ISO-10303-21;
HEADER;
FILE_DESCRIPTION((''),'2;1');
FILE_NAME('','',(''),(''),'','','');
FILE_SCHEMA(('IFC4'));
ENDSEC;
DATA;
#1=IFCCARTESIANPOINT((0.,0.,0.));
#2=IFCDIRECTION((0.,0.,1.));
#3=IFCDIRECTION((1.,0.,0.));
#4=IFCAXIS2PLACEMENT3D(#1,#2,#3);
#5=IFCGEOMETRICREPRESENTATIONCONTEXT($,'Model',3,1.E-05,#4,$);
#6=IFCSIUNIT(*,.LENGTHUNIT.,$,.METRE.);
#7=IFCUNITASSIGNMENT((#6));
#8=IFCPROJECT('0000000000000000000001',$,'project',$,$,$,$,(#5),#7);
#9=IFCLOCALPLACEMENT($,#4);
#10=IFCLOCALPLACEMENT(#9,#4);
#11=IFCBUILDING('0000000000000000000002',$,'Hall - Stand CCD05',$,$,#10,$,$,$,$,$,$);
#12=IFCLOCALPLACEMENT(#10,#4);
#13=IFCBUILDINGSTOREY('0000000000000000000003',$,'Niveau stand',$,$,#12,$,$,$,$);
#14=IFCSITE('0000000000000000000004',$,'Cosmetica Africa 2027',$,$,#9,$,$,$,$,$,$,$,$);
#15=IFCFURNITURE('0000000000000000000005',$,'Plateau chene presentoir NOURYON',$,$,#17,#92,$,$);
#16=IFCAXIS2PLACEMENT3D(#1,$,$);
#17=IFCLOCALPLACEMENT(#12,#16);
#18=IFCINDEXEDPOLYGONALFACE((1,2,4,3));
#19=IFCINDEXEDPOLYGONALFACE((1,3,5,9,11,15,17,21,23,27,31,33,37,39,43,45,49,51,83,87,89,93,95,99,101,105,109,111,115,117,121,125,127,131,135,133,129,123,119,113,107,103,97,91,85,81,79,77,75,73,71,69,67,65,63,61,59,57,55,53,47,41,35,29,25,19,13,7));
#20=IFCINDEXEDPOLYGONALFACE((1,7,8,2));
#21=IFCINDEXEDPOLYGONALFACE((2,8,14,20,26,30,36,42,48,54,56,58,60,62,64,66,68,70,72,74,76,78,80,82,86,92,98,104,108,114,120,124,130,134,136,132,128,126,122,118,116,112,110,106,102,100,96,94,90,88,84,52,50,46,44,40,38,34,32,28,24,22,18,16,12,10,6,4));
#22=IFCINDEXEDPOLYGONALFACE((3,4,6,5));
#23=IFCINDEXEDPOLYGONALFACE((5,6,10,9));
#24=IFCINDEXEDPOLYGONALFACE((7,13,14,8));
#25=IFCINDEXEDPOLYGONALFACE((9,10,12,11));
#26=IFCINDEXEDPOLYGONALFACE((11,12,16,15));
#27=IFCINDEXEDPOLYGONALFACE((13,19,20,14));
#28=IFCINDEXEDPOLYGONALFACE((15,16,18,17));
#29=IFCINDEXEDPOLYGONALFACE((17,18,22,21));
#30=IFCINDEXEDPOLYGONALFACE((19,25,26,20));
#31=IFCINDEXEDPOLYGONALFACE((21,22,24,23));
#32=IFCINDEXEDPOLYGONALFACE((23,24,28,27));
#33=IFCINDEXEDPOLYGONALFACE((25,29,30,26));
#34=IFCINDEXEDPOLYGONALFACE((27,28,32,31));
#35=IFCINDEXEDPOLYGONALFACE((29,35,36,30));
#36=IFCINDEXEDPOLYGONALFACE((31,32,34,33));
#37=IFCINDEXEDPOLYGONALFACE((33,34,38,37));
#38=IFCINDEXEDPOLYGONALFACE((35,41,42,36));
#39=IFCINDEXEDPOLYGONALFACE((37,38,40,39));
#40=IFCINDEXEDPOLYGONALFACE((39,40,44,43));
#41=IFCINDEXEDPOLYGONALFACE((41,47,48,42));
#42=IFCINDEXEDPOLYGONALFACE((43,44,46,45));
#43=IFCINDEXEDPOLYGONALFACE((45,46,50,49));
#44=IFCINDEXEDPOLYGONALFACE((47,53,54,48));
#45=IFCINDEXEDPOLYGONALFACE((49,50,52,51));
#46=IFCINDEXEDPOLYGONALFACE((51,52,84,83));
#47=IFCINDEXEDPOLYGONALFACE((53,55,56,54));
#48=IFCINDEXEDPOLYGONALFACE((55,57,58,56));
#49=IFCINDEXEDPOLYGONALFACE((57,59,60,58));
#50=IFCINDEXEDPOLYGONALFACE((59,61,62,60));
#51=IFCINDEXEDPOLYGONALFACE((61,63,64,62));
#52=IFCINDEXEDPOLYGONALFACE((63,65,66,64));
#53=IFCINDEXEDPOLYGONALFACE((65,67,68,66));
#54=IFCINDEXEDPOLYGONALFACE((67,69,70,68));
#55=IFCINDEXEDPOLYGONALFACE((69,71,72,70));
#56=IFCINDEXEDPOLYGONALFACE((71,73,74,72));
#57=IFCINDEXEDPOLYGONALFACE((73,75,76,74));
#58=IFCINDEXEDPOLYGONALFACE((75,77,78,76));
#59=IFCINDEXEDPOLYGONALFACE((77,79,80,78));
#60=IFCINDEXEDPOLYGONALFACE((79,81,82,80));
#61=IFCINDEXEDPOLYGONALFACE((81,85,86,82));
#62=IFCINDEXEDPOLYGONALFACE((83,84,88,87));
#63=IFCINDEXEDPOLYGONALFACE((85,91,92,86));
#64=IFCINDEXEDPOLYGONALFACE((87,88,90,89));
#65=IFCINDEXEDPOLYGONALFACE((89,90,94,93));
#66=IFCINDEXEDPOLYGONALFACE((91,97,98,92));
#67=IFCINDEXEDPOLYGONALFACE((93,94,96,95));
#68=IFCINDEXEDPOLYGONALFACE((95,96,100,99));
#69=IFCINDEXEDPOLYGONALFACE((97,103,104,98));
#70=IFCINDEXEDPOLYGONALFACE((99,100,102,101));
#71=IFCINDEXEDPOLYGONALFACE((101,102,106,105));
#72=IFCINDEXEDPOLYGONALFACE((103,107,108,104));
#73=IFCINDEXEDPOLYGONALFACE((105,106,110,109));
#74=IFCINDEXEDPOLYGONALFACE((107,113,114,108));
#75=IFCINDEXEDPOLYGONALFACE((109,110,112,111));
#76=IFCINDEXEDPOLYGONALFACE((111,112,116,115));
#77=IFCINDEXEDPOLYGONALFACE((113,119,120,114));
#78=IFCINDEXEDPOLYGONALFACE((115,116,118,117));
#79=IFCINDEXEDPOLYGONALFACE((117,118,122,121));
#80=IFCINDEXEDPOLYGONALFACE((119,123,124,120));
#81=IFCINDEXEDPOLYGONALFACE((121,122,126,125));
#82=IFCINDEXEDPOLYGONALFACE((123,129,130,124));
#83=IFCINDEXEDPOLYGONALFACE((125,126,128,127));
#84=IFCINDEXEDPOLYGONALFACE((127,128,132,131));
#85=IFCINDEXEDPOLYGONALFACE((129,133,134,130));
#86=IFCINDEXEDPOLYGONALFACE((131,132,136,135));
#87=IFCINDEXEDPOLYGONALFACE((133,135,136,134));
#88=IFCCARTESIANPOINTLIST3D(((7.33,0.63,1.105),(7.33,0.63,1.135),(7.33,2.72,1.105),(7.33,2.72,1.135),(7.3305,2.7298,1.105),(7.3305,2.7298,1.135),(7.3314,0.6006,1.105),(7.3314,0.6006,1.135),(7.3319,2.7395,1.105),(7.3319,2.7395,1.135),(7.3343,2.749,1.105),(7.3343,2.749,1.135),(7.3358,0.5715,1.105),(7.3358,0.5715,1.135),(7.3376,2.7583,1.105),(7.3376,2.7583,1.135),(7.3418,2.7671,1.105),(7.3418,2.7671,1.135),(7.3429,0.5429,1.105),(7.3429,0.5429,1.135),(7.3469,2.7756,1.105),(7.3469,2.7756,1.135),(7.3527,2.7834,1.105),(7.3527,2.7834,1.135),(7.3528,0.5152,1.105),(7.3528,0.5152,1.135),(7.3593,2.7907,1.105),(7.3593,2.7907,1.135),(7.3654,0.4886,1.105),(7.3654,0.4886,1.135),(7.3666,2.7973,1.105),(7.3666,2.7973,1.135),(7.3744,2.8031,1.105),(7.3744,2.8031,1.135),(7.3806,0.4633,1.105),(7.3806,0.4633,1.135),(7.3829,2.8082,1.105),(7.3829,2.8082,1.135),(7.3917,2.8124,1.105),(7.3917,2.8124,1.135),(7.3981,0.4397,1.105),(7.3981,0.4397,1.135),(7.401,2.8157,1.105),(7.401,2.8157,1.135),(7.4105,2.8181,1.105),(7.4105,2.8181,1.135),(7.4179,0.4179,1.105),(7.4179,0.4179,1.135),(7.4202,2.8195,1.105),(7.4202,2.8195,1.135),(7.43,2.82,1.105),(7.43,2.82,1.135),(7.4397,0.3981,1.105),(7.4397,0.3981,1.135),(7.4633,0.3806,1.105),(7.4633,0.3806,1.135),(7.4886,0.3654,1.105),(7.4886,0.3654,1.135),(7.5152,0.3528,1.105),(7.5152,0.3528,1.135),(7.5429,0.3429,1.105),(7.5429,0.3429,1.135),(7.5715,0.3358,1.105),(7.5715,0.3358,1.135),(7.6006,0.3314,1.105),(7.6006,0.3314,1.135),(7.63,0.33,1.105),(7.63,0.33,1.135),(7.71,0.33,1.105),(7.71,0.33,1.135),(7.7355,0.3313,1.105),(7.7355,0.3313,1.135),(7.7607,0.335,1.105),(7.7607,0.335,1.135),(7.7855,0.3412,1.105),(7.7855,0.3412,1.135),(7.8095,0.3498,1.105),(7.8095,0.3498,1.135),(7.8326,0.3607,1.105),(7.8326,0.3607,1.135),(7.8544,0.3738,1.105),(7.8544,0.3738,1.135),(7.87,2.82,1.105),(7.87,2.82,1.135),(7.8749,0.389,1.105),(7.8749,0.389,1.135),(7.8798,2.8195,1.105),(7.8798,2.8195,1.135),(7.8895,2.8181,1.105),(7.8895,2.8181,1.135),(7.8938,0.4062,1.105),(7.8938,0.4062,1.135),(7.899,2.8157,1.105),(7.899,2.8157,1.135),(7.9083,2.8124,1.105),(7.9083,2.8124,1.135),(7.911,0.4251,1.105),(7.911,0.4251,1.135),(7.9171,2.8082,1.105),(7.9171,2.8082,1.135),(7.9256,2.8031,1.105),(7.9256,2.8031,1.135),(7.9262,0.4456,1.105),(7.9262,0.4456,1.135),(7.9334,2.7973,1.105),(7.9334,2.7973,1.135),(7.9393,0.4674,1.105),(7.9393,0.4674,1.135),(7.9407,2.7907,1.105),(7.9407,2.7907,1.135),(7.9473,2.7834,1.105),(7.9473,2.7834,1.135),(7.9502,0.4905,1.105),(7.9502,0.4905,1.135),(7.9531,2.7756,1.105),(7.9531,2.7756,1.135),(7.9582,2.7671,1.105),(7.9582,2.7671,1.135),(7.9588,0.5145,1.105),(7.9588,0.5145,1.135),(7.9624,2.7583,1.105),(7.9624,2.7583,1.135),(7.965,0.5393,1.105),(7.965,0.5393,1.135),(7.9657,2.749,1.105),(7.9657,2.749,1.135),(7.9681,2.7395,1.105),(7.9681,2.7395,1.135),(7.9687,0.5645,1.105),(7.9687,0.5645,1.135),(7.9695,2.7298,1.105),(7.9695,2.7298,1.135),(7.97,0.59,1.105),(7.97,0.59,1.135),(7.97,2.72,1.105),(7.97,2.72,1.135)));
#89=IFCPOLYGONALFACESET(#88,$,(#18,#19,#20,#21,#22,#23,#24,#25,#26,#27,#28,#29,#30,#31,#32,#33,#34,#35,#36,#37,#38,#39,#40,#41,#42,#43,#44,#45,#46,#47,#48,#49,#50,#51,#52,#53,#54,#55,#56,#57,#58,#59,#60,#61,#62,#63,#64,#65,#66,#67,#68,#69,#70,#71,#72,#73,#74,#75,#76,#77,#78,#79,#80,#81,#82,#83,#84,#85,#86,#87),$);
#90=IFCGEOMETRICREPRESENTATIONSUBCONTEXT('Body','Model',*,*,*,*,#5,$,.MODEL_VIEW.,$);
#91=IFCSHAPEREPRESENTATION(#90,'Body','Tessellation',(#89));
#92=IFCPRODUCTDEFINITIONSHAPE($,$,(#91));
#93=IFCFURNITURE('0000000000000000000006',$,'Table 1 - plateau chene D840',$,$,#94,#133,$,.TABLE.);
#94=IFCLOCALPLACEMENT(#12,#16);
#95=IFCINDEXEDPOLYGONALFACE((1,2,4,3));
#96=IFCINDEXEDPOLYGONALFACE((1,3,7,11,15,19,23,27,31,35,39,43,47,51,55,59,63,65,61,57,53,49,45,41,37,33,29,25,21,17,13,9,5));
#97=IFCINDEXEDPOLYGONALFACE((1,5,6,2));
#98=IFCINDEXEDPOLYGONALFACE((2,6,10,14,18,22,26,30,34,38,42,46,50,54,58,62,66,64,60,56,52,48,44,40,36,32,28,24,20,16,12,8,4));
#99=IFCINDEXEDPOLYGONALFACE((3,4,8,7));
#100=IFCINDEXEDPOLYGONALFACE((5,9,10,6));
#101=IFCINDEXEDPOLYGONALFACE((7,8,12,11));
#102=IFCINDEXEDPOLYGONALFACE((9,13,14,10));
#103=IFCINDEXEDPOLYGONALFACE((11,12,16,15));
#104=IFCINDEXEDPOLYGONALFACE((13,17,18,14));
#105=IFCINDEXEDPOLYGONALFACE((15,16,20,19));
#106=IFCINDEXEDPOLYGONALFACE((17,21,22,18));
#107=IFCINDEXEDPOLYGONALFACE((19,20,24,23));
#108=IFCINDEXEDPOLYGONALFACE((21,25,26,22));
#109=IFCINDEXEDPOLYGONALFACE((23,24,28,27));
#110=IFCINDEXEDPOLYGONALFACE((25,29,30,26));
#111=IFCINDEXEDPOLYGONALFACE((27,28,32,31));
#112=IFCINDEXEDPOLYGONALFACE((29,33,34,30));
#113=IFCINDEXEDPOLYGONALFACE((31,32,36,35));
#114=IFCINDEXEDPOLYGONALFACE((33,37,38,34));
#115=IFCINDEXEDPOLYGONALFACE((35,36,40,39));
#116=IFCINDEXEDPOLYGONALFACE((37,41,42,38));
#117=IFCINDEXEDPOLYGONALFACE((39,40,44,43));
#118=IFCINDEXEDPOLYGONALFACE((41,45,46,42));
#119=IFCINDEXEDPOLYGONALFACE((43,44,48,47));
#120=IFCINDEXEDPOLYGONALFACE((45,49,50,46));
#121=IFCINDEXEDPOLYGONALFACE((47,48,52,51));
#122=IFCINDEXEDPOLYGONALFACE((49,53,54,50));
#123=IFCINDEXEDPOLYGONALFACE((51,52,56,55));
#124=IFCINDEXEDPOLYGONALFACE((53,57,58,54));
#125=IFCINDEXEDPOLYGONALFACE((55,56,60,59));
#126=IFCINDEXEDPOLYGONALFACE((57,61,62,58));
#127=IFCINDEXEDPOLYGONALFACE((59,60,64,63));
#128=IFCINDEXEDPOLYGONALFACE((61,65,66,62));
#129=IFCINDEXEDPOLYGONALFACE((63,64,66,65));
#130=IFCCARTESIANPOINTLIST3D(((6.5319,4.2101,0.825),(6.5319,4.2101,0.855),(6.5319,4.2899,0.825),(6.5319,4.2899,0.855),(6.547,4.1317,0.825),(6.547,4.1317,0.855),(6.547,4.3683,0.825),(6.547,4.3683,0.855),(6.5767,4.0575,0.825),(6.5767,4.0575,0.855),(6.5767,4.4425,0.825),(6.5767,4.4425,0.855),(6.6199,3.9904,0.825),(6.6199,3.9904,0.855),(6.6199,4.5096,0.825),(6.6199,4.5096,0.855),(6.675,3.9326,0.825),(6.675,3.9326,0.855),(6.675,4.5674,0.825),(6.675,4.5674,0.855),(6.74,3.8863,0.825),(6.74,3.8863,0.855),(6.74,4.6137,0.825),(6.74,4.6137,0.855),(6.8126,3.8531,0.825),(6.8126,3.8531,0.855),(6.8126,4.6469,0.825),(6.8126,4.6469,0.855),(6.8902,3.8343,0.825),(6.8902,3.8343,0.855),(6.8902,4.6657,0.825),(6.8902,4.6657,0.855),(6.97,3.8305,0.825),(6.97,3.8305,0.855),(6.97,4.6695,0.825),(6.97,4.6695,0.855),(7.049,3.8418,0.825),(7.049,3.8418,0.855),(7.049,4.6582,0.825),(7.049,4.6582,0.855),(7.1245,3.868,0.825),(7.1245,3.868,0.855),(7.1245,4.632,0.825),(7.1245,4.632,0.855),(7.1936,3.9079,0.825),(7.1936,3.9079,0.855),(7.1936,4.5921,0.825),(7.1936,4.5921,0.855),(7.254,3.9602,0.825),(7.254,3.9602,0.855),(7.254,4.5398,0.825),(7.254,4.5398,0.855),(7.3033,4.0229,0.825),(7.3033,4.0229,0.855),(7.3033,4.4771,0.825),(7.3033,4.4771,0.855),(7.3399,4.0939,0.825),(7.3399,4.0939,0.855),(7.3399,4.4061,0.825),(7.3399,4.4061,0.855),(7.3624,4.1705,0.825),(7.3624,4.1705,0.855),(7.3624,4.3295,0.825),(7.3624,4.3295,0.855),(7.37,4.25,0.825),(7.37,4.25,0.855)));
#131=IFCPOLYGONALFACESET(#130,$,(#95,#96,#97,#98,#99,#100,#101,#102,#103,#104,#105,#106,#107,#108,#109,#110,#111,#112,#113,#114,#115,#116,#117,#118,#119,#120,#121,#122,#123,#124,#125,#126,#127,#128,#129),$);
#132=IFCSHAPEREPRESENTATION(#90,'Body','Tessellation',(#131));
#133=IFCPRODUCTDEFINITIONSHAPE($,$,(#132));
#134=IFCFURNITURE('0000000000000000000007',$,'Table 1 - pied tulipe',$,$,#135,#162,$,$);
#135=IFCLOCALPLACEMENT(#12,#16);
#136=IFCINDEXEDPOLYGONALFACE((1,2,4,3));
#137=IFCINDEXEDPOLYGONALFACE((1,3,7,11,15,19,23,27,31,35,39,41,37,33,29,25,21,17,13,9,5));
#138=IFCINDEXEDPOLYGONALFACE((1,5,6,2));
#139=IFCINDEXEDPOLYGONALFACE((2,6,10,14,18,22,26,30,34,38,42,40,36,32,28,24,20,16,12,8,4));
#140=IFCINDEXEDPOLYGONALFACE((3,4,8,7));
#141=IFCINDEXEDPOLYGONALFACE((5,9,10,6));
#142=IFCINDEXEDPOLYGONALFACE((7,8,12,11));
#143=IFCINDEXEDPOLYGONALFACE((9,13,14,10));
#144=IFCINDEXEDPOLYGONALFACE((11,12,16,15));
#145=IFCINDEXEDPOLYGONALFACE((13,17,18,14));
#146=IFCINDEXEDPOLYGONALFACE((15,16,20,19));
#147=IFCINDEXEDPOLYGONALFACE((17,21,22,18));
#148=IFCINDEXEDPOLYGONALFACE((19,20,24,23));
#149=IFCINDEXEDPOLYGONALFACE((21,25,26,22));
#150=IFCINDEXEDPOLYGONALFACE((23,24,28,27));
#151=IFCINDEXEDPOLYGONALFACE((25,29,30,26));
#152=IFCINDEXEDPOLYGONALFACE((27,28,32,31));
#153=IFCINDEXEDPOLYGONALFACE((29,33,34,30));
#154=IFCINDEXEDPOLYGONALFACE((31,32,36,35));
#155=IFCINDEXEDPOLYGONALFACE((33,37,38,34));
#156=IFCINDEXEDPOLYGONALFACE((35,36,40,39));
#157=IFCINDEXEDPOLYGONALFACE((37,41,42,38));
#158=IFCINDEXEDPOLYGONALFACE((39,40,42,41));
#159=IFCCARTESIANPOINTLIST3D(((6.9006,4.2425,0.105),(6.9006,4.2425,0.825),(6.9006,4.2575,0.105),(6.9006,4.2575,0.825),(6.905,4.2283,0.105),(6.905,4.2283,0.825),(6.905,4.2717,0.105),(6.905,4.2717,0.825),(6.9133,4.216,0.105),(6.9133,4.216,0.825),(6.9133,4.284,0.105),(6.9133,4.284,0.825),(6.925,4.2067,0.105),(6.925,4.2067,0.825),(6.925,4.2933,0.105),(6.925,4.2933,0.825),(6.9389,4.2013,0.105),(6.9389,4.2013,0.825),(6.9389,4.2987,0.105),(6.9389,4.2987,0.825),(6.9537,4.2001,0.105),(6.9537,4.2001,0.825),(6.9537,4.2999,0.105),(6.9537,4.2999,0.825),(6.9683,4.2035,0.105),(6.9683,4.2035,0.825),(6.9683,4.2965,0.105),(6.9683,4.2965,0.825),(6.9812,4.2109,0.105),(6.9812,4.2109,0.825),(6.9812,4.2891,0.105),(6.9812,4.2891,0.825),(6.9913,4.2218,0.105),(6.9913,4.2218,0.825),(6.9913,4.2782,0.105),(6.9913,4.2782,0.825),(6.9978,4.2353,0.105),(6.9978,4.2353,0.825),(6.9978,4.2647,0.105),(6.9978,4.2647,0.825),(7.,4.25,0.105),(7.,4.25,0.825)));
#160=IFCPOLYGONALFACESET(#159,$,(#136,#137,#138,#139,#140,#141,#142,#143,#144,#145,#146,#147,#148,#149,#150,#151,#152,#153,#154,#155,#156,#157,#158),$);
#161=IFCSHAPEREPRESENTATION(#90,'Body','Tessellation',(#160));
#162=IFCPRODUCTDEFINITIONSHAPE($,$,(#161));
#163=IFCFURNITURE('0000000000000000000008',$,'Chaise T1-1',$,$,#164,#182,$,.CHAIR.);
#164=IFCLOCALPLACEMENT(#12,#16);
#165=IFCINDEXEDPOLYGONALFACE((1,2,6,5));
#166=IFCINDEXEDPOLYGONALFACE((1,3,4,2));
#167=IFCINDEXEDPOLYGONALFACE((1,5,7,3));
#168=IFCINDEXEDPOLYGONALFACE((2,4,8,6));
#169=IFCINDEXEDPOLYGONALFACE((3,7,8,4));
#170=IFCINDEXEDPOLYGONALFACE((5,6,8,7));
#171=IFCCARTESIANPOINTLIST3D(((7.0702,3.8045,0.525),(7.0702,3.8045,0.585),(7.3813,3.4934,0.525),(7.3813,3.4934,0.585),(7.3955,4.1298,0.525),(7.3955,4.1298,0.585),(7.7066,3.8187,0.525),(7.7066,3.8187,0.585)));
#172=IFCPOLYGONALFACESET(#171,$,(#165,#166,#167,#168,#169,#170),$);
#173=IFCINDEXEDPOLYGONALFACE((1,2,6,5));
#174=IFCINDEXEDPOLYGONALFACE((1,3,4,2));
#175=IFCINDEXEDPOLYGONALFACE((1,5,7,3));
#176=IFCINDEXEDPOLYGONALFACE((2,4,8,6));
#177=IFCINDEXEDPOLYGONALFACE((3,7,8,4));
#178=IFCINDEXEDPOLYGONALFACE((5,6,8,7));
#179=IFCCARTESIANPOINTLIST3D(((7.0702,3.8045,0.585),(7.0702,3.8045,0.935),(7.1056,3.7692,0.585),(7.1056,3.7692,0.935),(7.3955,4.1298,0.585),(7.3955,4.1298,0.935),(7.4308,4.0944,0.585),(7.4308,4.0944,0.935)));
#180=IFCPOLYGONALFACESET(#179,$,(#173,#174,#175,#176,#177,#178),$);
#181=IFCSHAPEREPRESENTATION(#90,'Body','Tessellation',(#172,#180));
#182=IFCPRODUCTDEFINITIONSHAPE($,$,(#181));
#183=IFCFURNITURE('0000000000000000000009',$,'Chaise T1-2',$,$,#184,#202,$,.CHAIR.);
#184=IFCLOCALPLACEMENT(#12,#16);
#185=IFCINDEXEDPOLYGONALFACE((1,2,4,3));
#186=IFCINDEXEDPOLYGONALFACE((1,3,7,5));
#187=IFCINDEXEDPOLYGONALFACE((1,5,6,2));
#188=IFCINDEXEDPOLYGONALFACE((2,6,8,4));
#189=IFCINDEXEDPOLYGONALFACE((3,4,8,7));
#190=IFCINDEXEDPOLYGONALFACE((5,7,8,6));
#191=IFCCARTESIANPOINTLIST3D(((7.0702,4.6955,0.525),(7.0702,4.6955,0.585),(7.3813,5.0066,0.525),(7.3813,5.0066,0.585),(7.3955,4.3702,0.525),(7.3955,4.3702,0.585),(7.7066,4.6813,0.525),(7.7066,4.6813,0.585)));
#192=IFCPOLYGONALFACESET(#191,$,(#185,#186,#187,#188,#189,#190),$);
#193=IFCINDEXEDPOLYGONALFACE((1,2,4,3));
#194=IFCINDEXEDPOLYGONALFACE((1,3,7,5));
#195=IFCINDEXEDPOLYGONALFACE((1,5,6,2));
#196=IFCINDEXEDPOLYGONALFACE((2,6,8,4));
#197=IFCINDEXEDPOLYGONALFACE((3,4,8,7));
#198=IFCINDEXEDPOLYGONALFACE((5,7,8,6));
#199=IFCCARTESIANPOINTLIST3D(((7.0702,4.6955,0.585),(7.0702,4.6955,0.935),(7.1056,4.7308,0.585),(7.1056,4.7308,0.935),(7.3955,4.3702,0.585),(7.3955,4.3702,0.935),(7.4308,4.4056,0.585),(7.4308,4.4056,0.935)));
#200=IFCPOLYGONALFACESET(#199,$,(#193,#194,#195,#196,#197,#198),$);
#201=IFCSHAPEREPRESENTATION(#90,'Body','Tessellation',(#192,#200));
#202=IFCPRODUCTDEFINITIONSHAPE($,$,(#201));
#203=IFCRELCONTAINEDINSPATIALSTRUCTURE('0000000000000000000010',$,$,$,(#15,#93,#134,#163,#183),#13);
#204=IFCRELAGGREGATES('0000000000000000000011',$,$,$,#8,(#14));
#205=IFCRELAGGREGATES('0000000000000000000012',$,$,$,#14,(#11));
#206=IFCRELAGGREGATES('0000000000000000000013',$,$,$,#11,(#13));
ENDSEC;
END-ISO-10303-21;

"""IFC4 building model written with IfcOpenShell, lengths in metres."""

from ifc_helpers import new_model, si_unit, frame, frame_2d, origin_with_axes, place, context, subcontext, project, spatial, polyline, circle, outline, extrude, element, save


model = new_model("IFC4")

# Units and contexts
model_context = context("Model", 3, precision=1e-05, world=origin_with_axes())
body_context = subcontext(model_context, "Body", "Model", "MODEL_VIEW")
ifc_project = project(units=[si_unit("LENGTHUNIT", "METRE")], contexts=[model_context])

# Site, building, storey
site_placement = place(None, origin_with_axes())
site = spatial("IfcSite", under=ifc_project, at=site_placement, Name="Cosmetica Africa 2027")
building_placement = place(site_placement, origin_with_axes())
building = spatial("IfcBuilding", under=site, at=building_placement, Name="Hall - Stand CCD05")
storey_placement = place(building_placement, origin_with_axes())
storey = spatial("IfcBuildingStorey", under=building, at=storey_placement, Name="Niveau stand")

# Furniture
furniture_1_placement = place(storey_placement, origin_with_axes())
element("IfcFurniture", 1, at=furniture_1_placement, inside=storey, Name="Plateau chene presentoir NOURYON", context=body_context, shape_type="SweptSolid", body=[
    extrude(outline(polyline([(7.33, 0.63), (7.3314, 0.6006), (7.3358, 0.5715), (7.3429, 0.5429), (7.3528, 0.5152), (7.3654, 0.4886), (7.3806, 0.4633), (7.3981, 0.4397), (7.4179, 0.4179), (7.4397, 0.3981), (7.4633, 0.3806), (7.4886, 0.3654), (7.5152, 0.3528), (7.5429, 0.3429), (7.5715, 0.3358), (7.6006, 0.3314), (7.63, 0.33), (7.71, 0.33), (7.7355, 0.3313), (7.7607, 0.335), (7.7855, 0.3412), (7.8095, 0.3498), (7.8326, 0.3607), (7.8544, 0.3738), (7.8749, 0.389), (7.8938, 0.4062), (7.911, 0.4251), (7.9262, 0.4456), (7.9393, 0.4674), (7.9502, 0.4905), (7.9588, 0.5145), (7.965, 0.5393), (7.9687, 0.5645), (7.97, 0.59), (7.97, 2.72), (7.9695, 2.7298), (7.9681, 2.7395), (7.9657, 2.749), (7.9624, 2.7583), (7.9582, 2.7671), (7.9531, 2.7756), (7.9473, 2.7834), (7.9407, 2.7907), (7.9334, 2.7973), (7.9256, 2.8031), (7.9171, 2.8082), (7.9083, 2.8124), (7.899, 2.8157), (7.8895, 2.8181), (7.8798, 2.8195), (7.87, 2.82), (7.43, 2.82), (7.4202, 2.8195), (7.4105, 2.8181), (7.401, 2.8157), (7.3917, 2.8124), (7.3829, 2.8082), (7.3744, 2.8031), (7.3666, 2.7973), (7.3593, 2.7907), (7.3527, 2.7834), (7.3469, 2.7756), (7.3418, 2.7671), (7.3376, 2.7583), (7.3343, 2.749), (7.3319, 2.7395), (7.3305, 2.7298), (7.33, 2.72), (7.33, 0.63)])), frame((0.0, 0.0, 1.105)), (0.0, 0.0, 1.0), 0.03),
])
furniture_2_placement = place(storey_placement, origin_with_axes())
element("IfcFurniture", 2, at=furniture_2_placement, inside=storey, Name="Table 1 - plateau chene D840", PredefinedType="TABLE", context=body_context, shape_type="SweptSolid", body=[
    extrude(circle(Radius=0.42, at=frame_2d((6.95, 4.25))), frame((0.0, 0.0, 0.825)), (0.0, 0.0, 1.0), 0.03),
])
furniture_3_placement = place(storey_placement, origin_with_axes())
element("IfcFurniture", 3, at=furniture_3_placement, inside=storey, Name="Table 1 - pied tulipe", context=body_context, shape_type="SweptSolid", body=[
    extrude(circle(Radius=0.05, at=frame_2d((6.95, 4.25))), frame((0.0, 0.0, 0.105)), (0.0, 0.0, 1.0), 0.72),
])
furniture_4_placement = place(storey_placement, origin_with_axes())
element("IfcFurniture", 4, at=furniture_4_placement, inside=storey, Name="Chaise T1-1", PredefinedType="CHAIR", context=body_context, shape_type="SweptSolid", body=[
    extrude(outline(polyline([(7.3813, 3.4934), (7.7066, 3.8187), (7.3955, 4.1298), (7.0702, 3.8045), (7.3813, 3.4934)])), frame((0.0, 0.0, 0.525)), (0.0, 0.0, 1.0), 0.06),
    extrude(outline(polyline([(7.1056, 3.7692), (7.4308, 4.0944), (7.3955, 4.1298), (7.0702, 3.8045), (7.1056, 3.7692)])), frame((0.0, 0.0, 0.585)), (0.0, 0.0, 1.0), 0.35),
])
furniture_5_placement = place(storey_placement, origin_with_axes())
element("IfcFurniture", 5, at=furniture_5_placement, inside=storey, Name="Chaise T1-2", PredefinedType="CHAIR", context=body_context, shape_type="SweptSolid", body=[
    extrude(outline(polyline([(7.7066, 4.6813), (7.3813, 5.0066), (7.0702, 4.6955), (7.3955, 4.3702), (7.7066, 4.6813)])), frame((0.0, 0.0, 0.525)), (0.0, 0.0, 1.0), 0.06),
    extrude(outline(polyline([(7.4308, 4.4056), (7.1056, 4.7308), (7.0702, 4.6955), (7.3955, 4.3702), (7.4308, 4.4056)])), frame((0.0, 0.0, 0.585)), (0.0, 0.0, 1.0), 0.35),
])

save(model, "model.ifc")
